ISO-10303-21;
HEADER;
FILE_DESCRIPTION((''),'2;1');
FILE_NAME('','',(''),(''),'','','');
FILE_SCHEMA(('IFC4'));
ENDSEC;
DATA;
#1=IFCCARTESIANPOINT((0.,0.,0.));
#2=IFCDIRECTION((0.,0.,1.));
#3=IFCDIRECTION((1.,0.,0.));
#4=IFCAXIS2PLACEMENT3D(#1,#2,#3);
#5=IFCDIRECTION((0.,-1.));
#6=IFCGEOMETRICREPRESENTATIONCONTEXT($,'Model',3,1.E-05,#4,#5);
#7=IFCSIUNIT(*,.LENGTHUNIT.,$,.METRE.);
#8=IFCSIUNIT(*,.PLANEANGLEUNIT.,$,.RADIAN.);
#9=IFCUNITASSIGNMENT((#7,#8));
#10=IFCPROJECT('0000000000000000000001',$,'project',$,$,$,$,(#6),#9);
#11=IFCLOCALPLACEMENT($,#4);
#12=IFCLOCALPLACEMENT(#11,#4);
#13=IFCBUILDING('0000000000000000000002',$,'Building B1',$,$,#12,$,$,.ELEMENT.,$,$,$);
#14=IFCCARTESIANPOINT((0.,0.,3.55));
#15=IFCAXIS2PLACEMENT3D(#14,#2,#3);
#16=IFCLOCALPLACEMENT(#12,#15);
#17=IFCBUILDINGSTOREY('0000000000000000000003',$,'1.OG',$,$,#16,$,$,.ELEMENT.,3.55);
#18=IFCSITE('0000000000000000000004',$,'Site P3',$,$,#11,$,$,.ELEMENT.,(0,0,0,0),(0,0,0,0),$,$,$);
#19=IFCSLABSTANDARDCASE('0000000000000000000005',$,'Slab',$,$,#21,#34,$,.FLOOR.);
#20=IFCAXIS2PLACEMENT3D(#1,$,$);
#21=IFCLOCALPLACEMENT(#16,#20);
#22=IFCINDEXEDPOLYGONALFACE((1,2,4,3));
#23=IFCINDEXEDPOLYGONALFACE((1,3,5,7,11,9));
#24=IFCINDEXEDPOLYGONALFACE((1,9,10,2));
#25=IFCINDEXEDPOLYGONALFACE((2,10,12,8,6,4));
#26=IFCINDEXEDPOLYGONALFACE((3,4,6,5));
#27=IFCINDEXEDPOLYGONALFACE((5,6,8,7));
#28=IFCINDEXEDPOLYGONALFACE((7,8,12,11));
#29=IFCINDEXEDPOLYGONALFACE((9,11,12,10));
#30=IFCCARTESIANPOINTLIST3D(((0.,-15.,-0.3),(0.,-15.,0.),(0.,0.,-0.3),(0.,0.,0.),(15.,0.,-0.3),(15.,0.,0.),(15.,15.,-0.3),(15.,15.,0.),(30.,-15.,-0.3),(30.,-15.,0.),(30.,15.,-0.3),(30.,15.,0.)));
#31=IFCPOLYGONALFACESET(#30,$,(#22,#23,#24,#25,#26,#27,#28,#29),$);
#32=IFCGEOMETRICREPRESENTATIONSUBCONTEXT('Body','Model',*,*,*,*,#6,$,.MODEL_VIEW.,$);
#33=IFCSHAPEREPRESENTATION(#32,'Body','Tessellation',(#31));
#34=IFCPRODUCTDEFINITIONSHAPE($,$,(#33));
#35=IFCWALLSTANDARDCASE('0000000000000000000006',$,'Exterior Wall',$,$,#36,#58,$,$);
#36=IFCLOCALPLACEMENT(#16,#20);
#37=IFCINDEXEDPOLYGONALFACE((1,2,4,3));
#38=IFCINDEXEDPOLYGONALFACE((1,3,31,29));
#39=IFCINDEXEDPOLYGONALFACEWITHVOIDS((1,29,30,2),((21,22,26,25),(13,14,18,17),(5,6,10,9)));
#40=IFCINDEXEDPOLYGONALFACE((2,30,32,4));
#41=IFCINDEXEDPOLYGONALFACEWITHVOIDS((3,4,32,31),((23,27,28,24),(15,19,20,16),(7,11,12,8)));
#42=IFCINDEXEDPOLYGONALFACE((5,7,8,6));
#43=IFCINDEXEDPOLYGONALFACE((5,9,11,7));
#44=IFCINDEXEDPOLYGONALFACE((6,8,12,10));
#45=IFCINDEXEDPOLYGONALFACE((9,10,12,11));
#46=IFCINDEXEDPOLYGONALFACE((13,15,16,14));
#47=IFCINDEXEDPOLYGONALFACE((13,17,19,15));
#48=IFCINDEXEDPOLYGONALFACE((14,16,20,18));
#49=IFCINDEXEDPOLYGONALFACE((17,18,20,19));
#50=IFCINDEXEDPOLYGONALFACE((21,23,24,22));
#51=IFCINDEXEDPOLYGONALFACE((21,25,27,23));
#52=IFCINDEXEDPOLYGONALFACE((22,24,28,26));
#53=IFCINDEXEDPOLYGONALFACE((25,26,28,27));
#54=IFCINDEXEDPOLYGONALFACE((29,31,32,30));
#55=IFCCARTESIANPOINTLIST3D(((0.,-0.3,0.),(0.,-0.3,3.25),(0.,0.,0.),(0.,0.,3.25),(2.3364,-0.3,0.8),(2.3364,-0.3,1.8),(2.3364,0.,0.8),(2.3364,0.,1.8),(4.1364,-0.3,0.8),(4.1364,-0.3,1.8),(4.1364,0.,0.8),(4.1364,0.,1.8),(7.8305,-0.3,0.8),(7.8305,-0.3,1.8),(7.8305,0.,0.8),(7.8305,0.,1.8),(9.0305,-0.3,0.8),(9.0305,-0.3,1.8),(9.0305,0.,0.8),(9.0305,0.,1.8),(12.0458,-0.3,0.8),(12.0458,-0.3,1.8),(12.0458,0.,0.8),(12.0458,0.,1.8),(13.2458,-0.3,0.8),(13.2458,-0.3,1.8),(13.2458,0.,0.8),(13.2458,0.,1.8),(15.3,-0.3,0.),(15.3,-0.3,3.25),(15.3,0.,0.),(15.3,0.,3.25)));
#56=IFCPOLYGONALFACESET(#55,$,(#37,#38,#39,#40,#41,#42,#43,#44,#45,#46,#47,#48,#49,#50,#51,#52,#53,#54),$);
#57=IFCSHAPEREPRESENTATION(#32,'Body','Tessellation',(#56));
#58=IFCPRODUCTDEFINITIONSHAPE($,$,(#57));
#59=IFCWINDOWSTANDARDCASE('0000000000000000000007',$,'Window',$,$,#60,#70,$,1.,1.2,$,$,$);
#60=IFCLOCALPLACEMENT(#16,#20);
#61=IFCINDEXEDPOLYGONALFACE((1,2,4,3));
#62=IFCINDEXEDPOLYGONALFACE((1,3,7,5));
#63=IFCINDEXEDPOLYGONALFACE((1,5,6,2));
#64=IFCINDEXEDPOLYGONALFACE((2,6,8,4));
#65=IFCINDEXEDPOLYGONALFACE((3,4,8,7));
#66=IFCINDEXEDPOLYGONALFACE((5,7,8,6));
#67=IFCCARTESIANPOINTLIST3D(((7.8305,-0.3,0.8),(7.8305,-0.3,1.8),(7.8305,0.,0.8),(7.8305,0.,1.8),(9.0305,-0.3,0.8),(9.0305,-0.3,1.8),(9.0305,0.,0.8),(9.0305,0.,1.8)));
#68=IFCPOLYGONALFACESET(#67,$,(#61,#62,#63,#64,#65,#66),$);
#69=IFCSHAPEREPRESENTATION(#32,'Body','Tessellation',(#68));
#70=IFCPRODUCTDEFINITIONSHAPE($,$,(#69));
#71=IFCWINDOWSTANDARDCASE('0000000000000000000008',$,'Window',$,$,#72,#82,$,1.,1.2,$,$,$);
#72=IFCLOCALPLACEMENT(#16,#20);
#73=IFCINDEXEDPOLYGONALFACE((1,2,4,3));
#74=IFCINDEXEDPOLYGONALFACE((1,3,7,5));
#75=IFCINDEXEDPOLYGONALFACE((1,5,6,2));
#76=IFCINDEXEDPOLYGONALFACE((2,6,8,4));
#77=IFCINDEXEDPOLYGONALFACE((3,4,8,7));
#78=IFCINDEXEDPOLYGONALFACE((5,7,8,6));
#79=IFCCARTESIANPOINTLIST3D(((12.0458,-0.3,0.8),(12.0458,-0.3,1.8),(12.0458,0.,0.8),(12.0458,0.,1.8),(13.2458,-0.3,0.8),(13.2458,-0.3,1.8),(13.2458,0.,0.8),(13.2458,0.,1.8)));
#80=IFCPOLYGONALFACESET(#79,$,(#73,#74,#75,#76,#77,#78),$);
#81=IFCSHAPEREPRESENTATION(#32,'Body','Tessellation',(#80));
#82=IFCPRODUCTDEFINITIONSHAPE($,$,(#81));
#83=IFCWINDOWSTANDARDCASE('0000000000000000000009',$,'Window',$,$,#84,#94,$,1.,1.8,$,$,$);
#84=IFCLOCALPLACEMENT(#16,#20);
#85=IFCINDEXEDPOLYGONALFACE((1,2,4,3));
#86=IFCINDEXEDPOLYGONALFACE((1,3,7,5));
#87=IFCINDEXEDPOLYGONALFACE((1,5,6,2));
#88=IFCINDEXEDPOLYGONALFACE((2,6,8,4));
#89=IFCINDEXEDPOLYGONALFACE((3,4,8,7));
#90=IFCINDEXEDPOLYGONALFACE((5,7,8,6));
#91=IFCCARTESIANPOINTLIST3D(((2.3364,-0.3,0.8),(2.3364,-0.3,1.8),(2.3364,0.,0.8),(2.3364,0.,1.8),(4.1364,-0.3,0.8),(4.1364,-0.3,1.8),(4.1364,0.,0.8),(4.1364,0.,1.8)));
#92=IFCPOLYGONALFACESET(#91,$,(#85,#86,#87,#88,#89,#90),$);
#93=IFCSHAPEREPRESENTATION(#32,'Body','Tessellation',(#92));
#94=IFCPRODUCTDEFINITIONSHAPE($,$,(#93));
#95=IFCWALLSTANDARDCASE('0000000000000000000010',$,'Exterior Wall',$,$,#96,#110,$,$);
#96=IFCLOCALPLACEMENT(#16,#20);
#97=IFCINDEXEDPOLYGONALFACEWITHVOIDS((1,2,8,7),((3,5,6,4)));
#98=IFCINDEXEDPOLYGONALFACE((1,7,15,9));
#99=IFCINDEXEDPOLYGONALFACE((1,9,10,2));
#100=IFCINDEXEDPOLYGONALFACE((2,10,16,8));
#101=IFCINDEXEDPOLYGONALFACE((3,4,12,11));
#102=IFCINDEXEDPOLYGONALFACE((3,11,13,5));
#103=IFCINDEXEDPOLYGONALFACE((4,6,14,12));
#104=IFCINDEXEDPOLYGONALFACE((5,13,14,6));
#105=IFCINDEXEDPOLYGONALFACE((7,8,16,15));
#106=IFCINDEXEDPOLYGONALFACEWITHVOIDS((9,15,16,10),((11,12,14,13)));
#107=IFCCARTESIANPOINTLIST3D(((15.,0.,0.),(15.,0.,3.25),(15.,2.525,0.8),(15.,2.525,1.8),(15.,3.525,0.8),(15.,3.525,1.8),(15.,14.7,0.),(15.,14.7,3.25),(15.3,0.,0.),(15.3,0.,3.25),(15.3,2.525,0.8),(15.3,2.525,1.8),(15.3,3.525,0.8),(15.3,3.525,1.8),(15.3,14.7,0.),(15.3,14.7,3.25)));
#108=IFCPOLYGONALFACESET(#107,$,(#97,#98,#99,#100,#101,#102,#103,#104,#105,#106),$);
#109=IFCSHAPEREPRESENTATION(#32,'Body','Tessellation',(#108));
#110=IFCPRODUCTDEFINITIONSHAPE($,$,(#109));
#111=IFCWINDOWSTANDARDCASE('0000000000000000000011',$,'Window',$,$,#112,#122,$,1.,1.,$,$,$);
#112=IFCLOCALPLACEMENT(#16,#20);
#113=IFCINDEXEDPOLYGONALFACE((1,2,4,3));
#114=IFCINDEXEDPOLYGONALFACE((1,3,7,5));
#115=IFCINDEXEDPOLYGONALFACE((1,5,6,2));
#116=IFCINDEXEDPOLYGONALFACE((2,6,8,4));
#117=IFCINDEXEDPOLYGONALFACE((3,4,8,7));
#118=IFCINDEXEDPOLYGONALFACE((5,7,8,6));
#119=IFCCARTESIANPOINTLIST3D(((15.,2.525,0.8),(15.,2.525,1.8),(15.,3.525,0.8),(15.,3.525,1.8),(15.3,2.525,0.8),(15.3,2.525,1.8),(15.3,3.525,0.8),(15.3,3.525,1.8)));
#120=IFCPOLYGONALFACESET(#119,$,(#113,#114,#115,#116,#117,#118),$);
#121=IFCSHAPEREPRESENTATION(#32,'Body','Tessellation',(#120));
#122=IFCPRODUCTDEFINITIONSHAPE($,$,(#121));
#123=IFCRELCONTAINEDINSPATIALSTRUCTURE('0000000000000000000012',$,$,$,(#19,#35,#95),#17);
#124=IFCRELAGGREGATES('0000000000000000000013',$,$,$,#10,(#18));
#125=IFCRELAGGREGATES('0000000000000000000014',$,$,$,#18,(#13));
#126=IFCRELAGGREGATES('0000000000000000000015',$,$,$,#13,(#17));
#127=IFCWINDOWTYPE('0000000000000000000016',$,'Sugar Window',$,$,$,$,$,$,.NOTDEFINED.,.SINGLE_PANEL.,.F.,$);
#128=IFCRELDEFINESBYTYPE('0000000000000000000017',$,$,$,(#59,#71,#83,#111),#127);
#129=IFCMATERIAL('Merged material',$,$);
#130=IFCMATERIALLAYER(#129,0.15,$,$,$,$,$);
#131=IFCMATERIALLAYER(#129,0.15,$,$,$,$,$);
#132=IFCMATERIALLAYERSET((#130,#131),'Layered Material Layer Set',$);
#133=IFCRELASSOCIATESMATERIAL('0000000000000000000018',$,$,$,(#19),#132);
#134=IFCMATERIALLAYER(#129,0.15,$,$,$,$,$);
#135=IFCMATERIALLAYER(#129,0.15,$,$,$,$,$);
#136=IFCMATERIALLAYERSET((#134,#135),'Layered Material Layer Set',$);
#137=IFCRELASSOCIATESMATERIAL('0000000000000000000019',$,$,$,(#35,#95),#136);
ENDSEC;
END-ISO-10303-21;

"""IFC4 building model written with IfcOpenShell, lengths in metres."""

from ifc_helpers import new_model, si_unit, direction, frame, origin_with_axes, place, context, subcontext, project, spatial, polyline, outline, extrude, source, transform, mapped, material, layer, layer_set, layer_usage, type_object, element, fill, save


model = new_model("IFC4")

# Units and contexts
model_context = context("Model", 3, precision=1e-05, world=origin_with_axes(), true_north=direction((0.0, -1.0)))
body_context = subcontext(model_context, "Body", "Model", "MODEL_VIEW")
ifc_project = project(units=[si_unit("LENGTHUNIT", "METRE"), si_unit("PLANEANGLEUNIT", "RADIAN")], contexts=[model_context])

# Site, building, storey
site_placement = place(None, origin_with_axes())
site = spatial("IfcSite", under=ifc_project, at=site_placement, Name="Site P3", CompositionType="ELEMENT", RefLatitude=(0, 0, 0, 0), RefLongitude=(0, 0, 0, 0))
building_placement = place(site_placement, origin_with_axes())
building = spatial("IfcBuilding", under=site, at=building_placement, Name="Building B1", CompositionType="ELEMENT")
storey_placement = place(building_placement, frame((0.0, 0.0, 3.55), z_axis=(0.0, 0.0, 1.0), x_axis=(1.0, 0.0, 0.0)))
storey = spatial("IfcBuildingStorey", under=building, at=storey_placement, Name="1.OG", CompositionType="ELEMENT", Elevation=3.55)

# Slab
ifc_material = material(Name="Merged material")
ifc_layer_1 = layer(ifc_material, 0.15)
ifc_layer_2 = layer(ifc_material, 0.15)
ifc_layer_set_1 = layer_set([ifc_layer_1, ifc_layer_2], Name="Layered Material Layer Set")
ifc_layer_usage_1 = layer_usage(ifc_layer_set_1, "AXIS2", "POSITIVE", -0.15)
slab_placement = place(storey_placement, origin_with_axes())
element("IfcSlabStandardCase", 1, at=slab_placement, inside=storey, material=ifc_layer_usage_1, Name="Slab", PredefinedType="FLOOR", context=body_context, shape_type="SweptSolid", body=[
    extrude(outline(polyline([(0.0, -15.0), (30.0, -15.0), (30.0, 15.0), (15.0, 15.0), (15.0, 0.0), (0.0, 0.0), (0.0, -15.0)])), frame((0.0, 0.0, -0.3), z_axis=(0.0, 0.0, 1.0), x_axis=(1.0, 0.0, 0.0)), (0.0, 0.0, 1.0), 0.3),
])

# Wall, openings, windows
ifc_layer_3 = layer(ifc_material, 0.15)
ifc_layer_4 = layer(ifc_material, 0.15)
ifc_layer_set_2 = layer_set([ifc_layer_3, ifc_layer_4], Name="Layered Material Layer Set")
ifc_layer_usage_2 = layer_usage(ifc_layer_set_2, "AXIS2", "POSITIVE", -0.15)
wall_1_placement = place(storey_placement, frame((15.3, -0.15, 0.0), z_axis=(0.0, 0.0, 1.0), x_axis=(-1.0, 0.0, 0.0)))
wall_1 = element("IfcWallStandardCase", 2, at=wall_1_placement, inside=storey, material=ifc_layer_usage_2, Name="Exterior Wall", context=body_context, shape_type="SweptSolid", body=[
    extrude(outline(polyline([(0.0, 0.15), (15.3, 0.15), (15.3, -0.15), (0.0, -0.15), (0.0, 0.15)])), origin_with_axes(), (0.0, 0.0, 1.0), 3.25),
])
opening_1_placement = place(wall_1_placement, frame((11.1636, 0.0, 0.8), z_axis=(0.0, 0.0, 1.0), x_axis=(1.0, 0.0, 0.0)))
opening_1 = element("IfcOpeningStandardCase", 3, at=opening_1_placement, cuts=wall_1, context=body_context, shape_type="SweptSolid", body=[
    extrude(outline(polyline([(0.0, 0.0), (0.0, 1.8), (1.0, 1.8), (1.0, 0.0), (0.0, 0.0)])), frame((0.0, -0.15, 0.0), z_axis=(0.0, 1.0, 0.0), x_axis=(0.0, 0.0, 1.0)), (0.0, 0.0, 1.0), 0.3),
])
opening_2_placement = place(wall_1_placement, frame((6.2695, 0.0, 0.8), z_axis=(0.0, 0.0, 1.0), x_axis=(1.0, 0.0, 0.0)))
opening_2 = element("IfcOpeningStandardCase", 4, at=opening_2_placement, cuts=wall_1, context=body_context, shape_type="SweptSolid", body=[
    extrude(outline(polyline([(0.0, 0.0), (0.0, 1.2), (1.0, 1.2), (1.0, 0.0), (0.0, 0.0)])), frame((0.0, -0.15, 0.0), z_axis=(0.0, 1.0, 0.0), x_axis=(0.0, 0.0, 1.0)), (0.0, 0.0, 1.0), 0.3),
])
opening_3_placement = place(wall_1_placement, frame((2.0542, 0.0, 0.8), z_axis=(0.0, 0.0, 1.0), x_axis=(1.0, 0.0, 0.0)))
opening_3 = element("IfcOpeningStandardCase", 5, at=opening_3_placement, cuts=wall_1, context=body_context, shape_type="SweptSolid", body=[
    extrude(outline(polyline([(0.0, 0.0), (0.0, 1.2), (1.0, 1.2), (1.0, 0.0), (0.0, 0.0)])), frame((0.0, -0.15, 0.0), z_axis=(0.0, 1.0, 0.0), x_axis=(0.0, 0.0, 1.0)), (0.0, 0.0, 1.0), 0.3),
])
window_type = type_object("IfcWindowType", Name="Sugar Window", ParameterTakesPrecedence=False, PartitioningType="SINGLE_PANEL", PredefinedType="NOTDEFINED")
shared_shape_1 = source(origin_with_axes(), body_context, "Body", "SweptSolid", [
    extrude(outline(polyline([(0.0, 0.0), (0.0, 1.2), (1.0, 1.2), (1.0, 0.0), (0.0, 0.0)])), frame((0.0, -0.15, 0.0), z_axis=(0.0, 1.0, 0.0), x_axis=(0.0, 0.0, 1.0)), (0.0, 0.0, 1.0), 0.3),
])
window_1_placement = place(opening_2_placement, origin_with_axes())
window_1 = element("IfcWindowStandardCase", 6, at=window_1_placement, type_object=window_type, Name="Window", OverallHeight=1.0, OverallWidth=1.2, context=body_context, shape_type="MappedRepresentation", body=[
    mapped(shared_shape_1, transform((0.0, 0.0, 0.0))),
])
fill(opening_2, window_1)
window_2_placement = place(opening_3_placement, origin_with_axes())
window_2 = element("IfcWindowStandardCase", 7, at=window_2_placement, type_object=window_type, Name="Window", OverallHeight=1.0, OverallWidth=1.2, context=body_context, shape_type="MappedRepresentation", body=[
    mapped(shared_shape_1, transform((0.0, 0.0, 0.0))),
])
fill(opening_3, window_2)
shared_shape_2 = source(origin_with_axes(), body_context, "Body", "SweptSolid", [
    extrude(outline(polyline([(0.0, 0.0), (0.0, 1.8), (1.0, 1.8), (1.0, 0.0), (0.0, 0.0)])), frame((0.0, -0.15, 0.0), z_axis=(0.0, 1.0, 0.0), x_axis=(0.0, 0.0, 1.0)), (0.0, 0.0, 1.0), 0.3),
])
window_3_placement = place(opening_1_placement, origin_with_axes())
window_3 = element("IfcWindowStandardCase", 8, at=window_3_placement, type_object=window_type, Name="Window", OverallHeight=1.0, OverallWidth=1.8, context=body_context, shape_type="MappedRepresentation", body=[
    mapped(shared_shape_2, transform((0.0, 0.0, 0.0))),
])
fill(opening_1, window_3)

# Wall, opening, window
wall_2_placement = place(storey_placement, frame((15.15, 14.7, 0.0), z_axis=(0.0, 0.0, 1.0), x_axis=(0.0, -1.0, 0.0)))
wall_2 = element("IfcWallStandardCase", 9, at=wall_2_placement, inside=storey, material=ifc_layer_usage_2, Name="Exterior Wall", context=body_context, shape_type="SweptSolid", body=[
    extrude(outline(polyline([(0.0, 0.15), (14.7, 0.15), (14.7, -0.15), (0.0, -0.15), (0.0, 0.15)])), origin_with_axes(), (0.0, 0.0, 1.0), 3.25),
])
opening_4_placement = place(wall_2_placement, frame((11.175, 0.0, 0.8), z_axis=(0.0, 0.0, 1.0), x_axis=(1.0, 0.0, 0.0)))
opening_4 = element("IfcOpeningStandardCase", 10, at=opening_4_placement, cuts=wall_2, context=body_context, shape_type="SweptSolid", body=[
    extrude(outline(polyline([(0.0, 0.0), (0.0, 1.0), (1.0, 1.0), (1.0, 0.0), (0.0, 0.0)])), frame((0.0, -0.15, 0.0), z_axis=(0.0, 1.0, 0.0), x_axis=(0.0, 0.0, 1.0)), (0.0, 0.0, 1.0), 0.3),
])
shared_shape_3 = source(origin_with_axes(), body_context, "Body", "SweptSolid", [
    extrude(outline(polyline([(0.0, 0.0), (0.0, 1.0), (1.0, 1.0), (1.0, 0.0), (0.0, 0.0)])), frame((0.0, -0.15, 0.0), z_axis=(0.0, 1.0, 0.0), x_axis=(0.0, 0.0, 1.0)), (0.0, 0.0, 1.0), 0.3),
])
window_4_placement = place(opening_4_placement, origin_with_axes())
window_4 = element("IfcWindowStandardCase", 11, at=window_4_placement, type_object=window_type, Name="Window", OverallHeight=1.0, OverallWidth=1.0, context=body_context, shape_type="MappedRepresentation", body=[
    mapped(shared_shape_3, transform((0.0, 0.0, 0.0))),
])
fill(opening_4, window_4)

save(model, "model.ifc")
